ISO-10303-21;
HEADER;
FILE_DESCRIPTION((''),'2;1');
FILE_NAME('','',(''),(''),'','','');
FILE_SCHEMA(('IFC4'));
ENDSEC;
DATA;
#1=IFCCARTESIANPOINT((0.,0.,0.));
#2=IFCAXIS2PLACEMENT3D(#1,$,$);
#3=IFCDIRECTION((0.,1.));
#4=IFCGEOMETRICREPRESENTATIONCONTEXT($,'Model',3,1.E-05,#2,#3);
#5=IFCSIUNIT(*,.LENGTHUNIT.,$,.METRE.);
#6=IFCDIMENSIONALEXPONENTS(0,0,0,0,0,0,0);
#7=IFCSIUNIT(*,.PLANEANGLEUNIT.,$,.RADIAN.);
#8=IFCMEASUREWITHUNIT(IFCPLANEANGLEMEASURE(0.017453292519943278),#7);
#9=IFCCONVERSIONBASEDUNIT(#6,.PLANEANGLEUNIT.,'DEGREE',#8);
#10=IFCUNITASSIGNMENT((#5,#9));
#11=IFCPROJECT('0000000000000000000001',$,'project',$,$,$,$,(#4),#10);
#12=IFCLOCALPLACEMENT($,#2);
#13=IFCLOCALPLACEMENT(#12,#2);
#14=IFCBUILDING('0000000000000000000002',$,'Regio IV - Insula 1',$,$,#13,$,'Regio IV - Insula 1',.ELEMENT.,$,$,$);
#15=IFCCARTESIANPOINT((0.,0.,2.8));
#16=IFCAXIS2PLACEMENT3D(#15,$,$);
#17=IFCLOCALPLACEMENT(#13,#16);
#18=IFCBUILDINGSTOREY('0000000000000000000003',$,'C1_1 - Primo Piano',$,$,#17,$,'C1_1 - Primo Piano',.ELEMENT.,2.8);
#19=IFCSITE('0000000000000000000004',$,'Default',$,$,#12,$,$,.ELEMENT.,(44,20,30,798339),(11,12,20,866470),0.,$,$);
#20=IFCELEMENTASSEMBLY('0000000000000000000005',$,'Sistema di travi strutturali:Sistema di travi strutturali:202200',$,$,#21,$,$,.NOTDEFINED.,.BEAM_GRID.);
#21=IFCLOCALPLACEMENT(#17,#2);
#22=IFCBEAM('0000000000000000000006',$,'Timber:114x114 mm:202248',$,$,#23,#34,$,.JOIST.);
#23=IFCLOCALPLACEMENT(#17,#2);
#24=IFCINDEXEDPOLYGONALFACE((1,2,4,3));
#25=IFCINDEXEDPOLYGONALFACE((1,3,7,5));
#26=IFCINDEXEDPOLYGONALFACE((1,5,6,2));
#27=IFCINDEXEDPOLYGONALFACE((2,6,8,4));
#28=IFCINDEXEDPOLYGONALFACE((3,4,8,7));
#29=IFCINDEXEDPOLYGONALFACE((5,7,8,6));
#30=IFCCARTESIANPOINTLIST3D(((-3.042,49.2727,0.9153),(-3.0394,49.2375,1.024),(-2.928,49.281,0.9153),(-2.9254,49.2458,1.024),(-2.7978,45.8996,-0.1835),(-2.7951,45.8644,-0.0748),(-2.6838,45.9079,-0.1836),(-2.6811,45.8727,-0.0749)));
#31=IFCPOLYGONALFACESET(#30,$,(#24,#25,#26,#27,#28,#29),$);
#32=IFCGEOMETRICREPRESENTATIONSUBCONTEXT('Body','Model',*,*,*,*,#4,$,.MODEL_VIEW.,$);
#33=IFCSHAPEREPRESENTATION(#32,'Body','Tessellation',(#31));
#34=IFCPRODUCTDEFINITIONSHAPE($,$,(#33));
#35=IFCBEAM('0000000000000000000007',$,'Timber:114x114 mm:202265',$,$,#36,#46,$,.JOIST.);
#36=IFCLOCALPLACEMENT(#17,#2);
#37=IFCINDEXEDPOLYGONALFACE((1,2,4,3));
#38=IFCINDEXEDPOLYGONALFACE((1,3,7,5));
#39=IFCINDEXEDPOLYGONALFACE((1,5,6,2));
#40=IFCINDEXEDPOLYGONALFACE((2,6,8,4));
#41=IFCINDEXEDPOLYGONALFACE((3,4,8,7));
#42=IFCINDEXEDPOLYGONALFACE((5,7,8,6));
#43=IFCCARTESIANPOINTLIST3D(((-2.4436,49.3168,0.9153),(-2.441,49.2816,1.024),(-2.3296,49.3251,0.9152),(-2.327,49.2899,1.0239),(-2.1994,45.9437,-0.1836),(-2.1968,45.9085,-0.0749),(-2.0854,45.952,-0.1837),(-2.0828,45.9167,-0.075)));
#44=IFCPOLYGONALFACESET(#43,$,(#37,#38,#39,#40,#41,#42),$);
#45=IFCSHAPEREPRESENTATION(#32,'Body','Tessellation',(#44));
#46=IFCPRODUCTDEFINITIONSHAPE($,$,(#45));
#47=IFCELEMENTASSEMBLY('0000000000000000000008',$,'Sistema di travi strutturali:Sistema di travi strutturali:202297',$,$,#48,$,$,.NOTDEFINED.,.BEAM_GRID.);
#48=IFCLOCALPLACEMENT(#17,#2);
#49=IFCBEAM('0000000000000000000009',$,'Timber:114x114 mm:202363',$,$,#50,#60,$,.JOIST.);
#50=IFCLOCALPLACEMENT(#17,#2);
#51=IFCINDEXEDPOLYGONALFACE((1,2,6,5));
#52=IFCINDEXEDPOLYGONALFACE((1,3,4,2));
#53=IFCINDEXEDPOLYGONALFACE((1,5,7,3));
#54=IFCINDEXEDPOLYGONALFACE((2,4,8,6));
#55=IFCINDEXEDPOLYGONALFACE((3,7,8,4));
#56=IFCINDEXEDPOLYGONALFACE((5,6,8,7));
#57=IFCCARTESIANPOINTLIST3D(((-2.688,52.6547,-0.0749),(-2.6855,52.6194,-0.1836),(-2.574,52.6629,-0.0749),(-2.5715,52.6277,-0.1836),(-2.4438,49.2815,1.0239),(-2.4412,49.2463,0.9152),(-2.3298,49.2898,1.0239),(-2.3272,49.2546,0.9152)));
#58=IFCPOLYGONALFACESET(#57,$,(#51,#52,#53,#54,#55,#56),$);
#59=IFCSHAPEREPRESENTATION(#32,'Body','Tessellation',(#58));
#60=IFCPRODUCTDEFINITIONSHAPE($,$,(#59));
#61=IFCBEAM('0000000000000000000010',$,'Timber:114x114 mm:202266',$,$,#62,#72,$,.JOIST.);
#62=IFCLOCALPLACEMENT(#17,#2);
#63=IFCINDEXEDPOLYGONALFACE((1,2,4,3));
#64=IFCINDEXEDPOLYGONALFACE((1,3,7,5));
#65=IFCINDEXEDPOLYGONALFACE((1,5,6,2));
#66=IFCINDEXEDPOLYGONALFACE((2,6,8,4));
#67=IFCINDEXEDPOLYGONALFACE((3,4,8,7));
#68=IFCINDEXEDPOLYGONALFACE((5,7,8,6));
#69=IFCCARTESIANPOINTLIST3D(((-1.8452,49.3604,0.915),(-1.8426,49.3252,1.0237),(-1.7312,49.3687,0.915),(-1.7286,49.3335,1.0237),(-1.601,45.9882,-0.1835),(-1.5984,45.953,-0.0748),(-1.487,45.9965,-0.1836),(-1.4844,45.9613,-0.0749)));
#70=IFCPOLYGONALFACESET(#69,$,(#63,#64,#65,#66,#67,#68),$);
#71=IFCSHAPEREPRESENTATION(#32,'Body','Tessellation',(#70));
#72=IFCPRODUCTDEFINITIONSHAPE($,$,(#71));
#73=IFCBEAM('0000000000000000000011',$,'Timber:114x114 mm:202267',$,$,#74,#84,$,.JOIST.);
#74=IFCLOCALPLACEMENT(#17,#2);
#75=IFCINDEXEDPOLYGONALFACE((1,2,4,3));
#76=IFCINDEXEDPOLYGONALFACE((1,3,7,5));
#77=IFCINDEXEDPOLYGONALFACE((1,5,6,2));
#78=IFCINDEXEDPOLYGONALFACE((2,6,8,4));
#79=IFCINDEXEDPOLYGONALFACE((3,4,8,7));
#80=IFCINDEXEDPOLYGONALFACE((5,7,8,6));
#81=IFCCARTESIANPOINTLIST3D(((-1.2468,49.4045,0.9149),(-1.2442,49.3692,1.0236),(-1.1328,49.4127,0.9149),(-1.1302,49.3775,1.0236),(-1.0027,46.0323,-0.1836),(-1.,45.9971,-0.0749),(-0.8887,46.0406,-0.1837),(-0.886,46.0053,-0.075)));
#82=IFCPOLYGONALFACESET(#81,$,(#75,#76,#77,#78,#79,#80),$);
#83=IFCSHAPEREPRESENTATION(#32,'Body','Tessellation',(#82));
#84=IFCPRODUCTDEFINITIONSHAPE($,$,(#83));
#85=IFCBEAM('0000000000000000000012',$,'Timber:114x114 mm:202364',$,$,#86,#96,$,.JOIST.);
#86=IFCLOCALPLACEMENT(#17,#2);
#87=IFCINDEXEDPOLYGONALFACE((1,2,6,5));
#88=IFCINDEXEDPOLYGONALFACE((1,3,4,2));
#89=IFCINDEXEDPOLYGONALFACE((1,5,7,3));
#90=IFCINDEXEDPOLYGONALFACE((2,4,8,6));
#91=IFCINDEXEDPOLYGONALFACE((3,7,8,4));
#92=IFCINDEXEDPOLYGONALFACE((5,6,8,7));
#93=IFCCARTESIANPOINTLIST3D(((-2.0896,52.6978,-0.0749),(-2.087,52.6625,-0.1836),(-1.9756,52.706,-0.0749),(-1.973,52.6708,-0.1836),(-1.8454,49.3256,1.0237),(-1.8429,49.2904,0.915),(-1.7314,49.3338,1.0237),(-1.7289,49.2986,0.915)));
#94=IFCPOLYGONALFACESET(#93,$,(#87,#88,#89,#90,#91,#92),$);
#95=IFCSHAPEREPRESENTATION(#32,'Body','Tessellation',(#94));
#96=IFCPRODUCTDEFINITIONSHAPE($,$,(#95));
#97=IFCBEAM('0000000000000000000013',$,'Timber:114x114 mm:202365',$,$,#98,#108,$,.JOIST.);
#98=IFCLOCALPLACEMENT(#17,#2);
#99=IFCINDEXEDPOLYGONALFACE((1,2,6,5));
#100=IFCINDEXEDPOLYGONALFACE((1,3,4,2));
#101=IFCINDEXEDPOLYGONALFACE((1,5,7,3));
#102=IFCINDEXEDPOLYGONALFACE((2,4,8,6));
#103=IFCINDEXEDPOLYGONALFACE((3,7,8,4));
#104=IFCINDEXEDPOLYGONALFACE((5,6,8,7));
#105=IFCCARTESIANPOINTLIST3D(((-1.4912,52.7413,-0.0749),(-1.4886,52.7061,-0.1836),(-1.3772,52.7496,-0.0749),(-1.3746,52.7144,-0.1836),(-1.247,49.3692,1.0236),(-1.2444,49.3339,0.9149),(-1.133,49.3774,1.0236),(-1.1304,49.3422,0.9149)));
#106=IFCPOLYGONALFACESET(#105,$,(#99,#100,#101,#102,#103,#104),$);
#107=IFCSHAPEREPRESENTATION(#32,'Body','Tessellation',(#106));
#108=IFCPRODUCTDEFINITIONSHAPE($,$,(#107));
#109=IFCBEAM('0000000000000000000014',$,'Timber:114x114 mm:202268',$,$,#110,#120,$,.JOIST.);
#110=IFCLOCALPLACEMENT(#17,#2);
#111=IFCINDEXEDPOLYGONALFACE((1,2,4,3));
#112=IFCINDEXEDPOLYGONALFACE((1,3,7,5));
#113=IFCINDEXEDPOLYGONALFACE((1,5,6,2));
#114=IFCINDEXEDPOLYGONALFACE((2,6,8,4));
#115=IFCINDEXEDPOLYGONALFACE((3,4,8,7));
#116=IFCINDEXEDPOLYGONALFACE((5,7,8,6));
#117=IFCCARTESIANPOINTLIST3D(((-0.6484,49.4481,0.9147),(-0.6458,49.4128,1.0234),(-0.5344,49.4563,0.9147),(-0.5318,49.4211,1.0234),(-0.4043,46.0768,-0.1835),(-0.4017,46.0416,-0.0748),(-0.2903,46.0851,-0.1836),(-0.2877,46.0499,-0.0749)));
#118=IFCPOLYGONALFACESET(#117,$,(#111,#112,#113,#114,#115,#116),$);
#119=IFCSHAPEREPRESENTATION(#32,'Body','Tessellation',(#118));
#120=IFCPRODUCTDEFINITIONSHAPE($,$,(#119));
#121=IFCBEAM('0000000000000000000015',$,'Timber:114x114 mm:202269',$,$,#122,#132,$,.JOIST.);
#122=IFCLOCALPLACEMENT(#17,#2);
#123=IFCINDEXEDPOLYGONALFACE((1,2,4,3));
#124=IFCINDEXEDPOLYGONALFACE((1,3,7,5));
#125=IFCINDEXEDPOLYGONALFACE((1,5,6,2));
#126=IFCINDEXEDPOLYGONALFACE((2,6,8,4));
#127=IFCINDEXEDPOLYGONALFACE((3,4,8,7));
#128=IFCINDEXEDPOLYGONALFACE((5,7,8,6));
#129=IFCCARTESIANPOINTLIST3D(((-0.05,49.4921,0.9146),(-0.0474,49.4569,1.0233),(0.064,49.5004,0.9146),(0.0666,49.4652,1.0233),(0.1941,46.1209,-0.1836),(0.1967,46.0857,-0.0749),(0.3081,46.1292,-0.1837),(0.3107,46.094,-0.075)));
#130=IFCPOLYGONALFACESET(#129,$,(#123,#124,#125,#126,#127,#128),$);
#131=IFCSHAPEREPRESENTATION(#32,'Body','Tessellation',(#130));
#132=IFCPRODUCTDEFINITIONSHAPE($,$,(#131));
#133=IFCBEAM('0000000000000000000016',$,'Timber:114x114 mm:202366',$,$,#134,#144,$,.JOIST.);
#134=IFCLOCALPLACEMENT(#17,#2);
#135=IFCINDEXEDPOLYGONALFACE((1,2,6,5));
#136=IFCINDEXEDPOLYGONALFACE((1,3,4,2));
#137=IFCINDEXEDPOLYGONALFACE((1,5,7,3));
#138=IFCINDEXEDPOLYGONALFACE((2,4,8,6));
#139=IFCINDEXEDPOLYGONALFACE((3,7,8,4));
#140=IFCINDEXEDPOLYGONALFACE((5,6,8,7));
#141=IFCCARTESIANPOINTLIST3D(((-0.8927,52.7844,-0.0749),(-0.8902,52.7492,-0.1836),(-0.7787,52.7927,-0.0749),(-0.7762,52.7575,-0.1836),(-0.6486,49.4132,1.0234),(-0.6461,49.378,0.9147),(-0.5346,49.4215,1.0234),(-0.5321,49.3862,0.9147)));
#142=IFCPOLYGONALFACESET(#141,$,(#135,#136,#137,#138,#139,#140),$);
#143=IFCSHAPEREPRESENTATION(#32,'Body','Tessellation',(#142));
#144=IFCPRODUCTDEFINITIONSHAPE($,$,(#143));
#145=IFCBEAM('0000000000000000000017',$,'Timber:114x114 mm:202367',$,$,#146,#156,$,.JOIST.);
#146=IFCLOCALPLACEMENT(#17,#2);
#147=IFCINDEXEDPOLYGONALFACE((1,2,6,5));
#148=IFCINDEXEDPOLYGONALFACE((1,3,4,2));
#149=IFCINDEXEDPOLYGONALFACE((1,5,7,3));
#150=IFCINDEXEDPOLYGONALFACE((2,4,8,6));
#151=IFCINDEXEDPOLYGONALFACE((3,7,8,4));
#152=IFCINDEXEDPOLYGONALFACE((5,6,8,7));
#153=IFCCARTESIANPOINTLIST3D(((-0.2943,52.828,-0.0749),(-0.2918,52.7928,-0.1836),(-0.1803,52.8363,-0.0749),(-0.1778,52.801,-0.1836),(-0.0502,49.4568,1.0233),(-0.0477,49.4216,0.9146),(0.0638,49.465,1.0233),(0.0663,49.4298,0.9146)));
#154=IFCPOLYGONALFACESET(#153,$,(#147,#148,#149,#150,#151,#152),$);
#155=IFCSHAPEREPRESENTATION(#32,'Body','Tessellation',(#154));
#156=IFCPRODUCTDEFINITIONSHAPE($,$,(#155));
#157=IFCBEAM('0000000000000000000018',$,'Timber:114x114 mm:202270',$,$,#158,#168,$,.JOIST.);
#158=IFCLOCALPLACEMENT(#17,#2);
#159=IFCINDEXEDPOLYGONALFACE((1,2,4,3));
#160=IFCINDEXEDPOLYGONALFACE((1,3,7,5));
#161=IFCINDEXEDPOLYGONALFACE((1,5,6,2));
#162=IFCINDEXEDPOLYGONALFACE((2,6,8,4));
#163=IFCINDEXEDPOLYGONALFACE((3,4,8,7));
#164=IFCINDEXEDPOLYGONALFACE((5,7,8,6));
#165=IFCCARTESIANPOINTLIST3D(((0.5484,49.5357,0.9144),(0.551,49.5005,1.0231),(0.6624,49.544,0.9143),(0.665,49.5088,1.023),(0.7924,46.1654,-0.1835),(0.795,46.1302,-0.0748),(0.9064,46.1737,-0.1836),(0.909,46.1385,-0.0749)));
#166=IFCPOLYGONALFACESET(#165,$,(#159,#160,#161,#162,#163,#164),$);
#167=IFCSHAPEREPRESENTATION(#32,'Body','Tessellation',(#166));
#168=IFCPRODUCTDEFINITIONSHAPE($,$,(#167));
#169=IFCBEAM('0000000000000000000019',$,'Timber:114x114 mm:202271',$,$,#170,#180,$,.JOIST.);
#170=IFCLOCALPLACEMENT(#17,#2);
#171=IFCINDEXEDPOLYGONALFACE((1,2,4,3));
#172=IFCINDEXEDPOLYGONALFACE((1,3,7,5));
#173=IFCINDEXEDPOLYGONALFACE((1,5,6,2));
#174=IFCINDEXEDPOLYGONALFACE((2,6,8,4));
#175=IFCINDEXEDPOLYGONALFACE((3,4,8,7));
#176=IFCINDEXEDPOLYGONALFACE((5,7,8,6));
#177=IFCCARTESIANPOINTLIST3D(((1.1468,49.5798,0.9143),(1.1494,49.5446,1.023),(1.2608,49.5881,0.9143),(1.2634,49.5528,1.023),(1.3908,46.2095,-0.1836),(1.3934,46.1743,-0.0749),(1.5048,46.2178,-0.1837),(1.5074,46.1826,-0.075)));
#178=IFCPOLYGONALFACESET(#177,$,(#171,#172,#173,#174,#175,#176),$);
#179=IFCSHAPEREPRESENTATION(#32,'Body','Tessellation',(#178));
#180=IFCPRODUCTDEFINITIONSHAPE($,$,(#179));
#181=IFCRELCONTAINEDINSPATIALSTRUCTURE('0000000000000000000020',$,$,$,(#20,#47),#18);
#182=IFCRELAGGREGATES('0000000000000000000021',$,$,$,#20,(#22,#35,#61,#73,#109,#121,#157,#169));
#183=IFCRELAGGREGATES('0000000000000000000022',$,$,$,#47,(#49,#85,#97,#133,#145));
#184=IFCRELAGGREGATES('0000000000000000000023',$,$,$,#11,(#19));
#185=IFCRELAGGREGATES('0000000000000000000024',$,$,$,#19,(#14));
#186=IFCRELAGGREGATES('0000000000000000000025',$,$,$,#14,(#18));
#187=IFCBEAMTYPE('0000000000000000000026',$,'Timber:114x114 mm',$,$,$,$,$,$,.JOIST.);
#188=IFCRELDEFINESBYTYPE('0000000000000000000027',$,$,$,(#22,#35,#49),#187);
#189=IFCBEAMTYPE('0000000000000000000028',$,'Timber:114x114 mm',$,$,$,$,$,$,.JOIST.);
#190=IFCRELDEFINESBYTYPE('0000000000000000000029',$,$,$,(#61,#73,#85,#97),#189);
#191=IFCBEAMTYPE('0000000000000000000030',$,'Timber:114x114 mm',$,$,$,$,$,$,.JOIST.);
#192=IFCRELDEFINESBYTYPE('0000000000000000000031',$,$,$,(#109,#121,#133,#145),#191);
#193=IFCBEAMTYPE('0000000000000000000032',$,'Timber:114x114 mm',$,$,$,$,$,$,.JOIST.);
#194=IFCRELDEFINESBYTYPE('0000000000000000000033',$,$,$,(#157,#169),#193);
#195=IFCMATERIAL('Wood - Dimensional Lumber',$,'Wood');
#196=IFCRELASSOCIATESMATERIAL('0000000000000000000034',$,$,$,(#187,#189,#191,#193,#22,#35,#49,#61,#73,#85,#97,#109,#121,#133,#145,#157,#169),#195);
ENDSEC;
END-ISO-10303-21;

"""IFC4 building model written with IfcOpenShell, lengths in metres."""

from ifc_helpers import new_model, entity, si_unit, converted_unit, direction, frame, origin, origin_2d_with_axis, place, context, subcontext, project, spatial, rectangle, extrude, source, transform, mapped, material, material_profile, profile_set, profile_usage, type_object, type_shapes, element, aggregate, save


model = new_model("IFC4")

# Units and contexts
model_context = context("Model", 3, precision=1e-05, world=origin(), true_north=direction((0.0, 1.0)))
body_context = subcontext(model_context, "Body", "Model", "MODEL_VIEW")
ifc_project = project(units=[si_unit("LENGTHUNIT", "METRE"), converted_unit("PLANEANGLEUNIT", "DEGREE", entity("IfcPlaneAngleMeasure", 0.017453292519943278), si_unit("PLANEANGLEUNIT", "RADIAN"), dimensions=[0, 0, 0, 0, 0, 0, 0])], contexts=[model_context])

# Site, building, storey
site_placement = place(None, origin())
site = spatial("IfcSite", under=ifc_project, at=site_placement, Name="Default", CompositionType="ELEMENT", RefLatitude=(44, 20, 30, 798339), RefLongitude=(11, 12, 20, 866470), RefElevation=0.0)
building_placement = place(site_placement, origin())
building = spatial("IfcBuilding", under=site, at=building_placement, Name="Regio IV - Insula 1", LongName="Regio IV - Insula 1", CompositionType="ELEMENT")
storey_placement = place(building_placement, frame((0.0, 0.0, 2.8)))
storey = spatial("IfcBuildingStorey", under=building, at=storey_placement, Name="C1_1 - Primo Piano", LongName="C1_1 - Primo Piano", CompositionType="ELEMENT", Elevation=2.8)

# Element assembly, beams
assembly_1_placement = place(storey_placement, origin())
assembly_1 = element("IfcElementAssembly", 1, at=assembly_1_placement, inside=storey, Name="Sistema di travi strutturali:Sistema di travi strutturali:202200", AssemblyPlace="NOTDEFINED", PredefinedType="BEAM_GRID")
ifc_material = material(Name="Wood - Dimensional Lumber", Category="Wood")
ifc_material_profile = material_profile(ifc_material, rectangle(XDim=5.294, YDim=0.1143, at=origin_2d_with_axis()), Name="114x114 mm")
ifc_profile_set = profile_set([ifc_material_profile], Name="114x114 mm")
ifc_profile_usage = profile_usage(ifc_profile_set, cardinal=8)
beam_type_1 = type_object("IfcBeamType", Name="Timber:114x114 mm", PredefinedType="JOIST", material=ifc_profile_set)
shared_shape_1 = source(origin(), body_context, "Body", "SweptSolid", [
    extrude(rectangle(XDim=3.556, YDim=0.1143, at=origin_2d_with_axis()), frame((0.0, 0.0, -0.0572), z_axis=(0.0, 0.0, 1.0), x_axis=(-1.0, 0.0, 0.0)), (0.0, 0.0, 1.0), 0.1143),
])
type_shapes(beam_type_1, [shared_shape_1])
beam_1_placement = place(assembly_1_placement, frame((-2.8616, 47.5727, 0.4202), z_axis=(0.022823, -0.308173, 0.951057), x_axis=(0.068685, -0.948573, -0.309017)))
beam_1 = element("IfcBeam", 2, at=beam_1_placement, type_object=beam_type_1, material=ifc_profile_usage, Name="Timber:114x114 mm:202248", PredefinedType="JOIST", context=body_context, shape_type="MappedRepresentation", body=[
    mapped(shared_shape_1, transform((0.0, 0.0, 0.0), scale=1.0)),
])
beam_2_placement = place(assembly_1_placement, frame((-2.2632, 47.6168, 0.4201), z_axis=(0.022823, -0.308173, 0.951057), x_axis=(0.068685, -0.948573, -0.309017)))
beam_2 = element("IfcBeam", 3, at=beam_2_placement, type_object=beam_type_1, material=ifc_profile_usage, Name="Timber:114x114 mm:202265", PredefinedType="JOIST", context=body_context, shape_type="MappedRepresentation", body=[
    mapped(shared_shape_1, transform((0.0, 0.0, 0.0), scale=1.0)),
])

# Element assembly, beam
assembly_2_placement = place(storey_placement, origin())
assembly_2 = element("IfcElementAssembly", 4, at=assembly_2_placement, inside=storey, Name="Sistema di travi strutturali:Sistema di travi strutturali:202297", AssemblyPlace="NOTDEFINED", PredefinedType="BEAM_GRID")
beam_3_placement = place(assembly_2_placement, frame((-2.5076, 50.9546, 0.4201), z_axis=(-0.022317, 0.30821, 0.951057), x_axis=(0.068685, -0.948573, 0.309017)))
beam_3 = element("IfcBeam", 5, at=beam_3_placement, type_object=beam_type_1, material=ifc_profile_usage, Name="Timber:114x114 mm:202363", PredefinedType="JOIST", context=body_context, shape_type="MappedRepresentation", body=[
    mapped(shared_shape_1, transform((0.0, 0.0, 0.0), scale=1.0)),
])

# Beams
beam_type_2 = type_object("IfcBeamType", Name="Timber:114x114 mm", PredefinedType="JOIST", material=ifc_profile_set)
shared_shape_2 = source(origin(), body_context, "Body", "SweptSolid", [
    extrude(rectangle(XDim=3.555, YDim=0.1143, at=origin_2d_with_axis()), frame((0.0, 0.0, -0.0572), z_axis=(0.0, 0.0, 1.0), x_axis=(-1.0, 0.0, 0.0)), (0.0, 0.0, 1.0), 0.1143),
])
type_shapes(beam_type_2, [shared_shape_2])
beam_4_placement = place(assembly_1_placement, frame((-1.6648, 47.6608, 0.4201), z_axis=(0.022823, -0.308173, 0.951057), x_axis=(0.068685, -0.948573, -0.309017)))
beam_4 = element("IfcBeam", 6, at=beam_4_placement, type_object=beam_type_2, material=ifc_profile_usage, Name="Timber:114x114 mm:202266", PredefinedType="JOIST", context=body_context, shape_type="MappedRepresentation", body=[
    mapped(shared_shape_2, transform((0.0, 0.0, 0.0), scale=1.0)),
])
beam_5_placement = place(assembly_1_placement, frame((-1.0664, 47.7049, 0.42), z_axis=(0.022823, -0.308173, 0.951057), x_axis=(0.068685, -0.948573, -0.309017)))
beam_5 = element("IfcBeam", 7, at=beam_5_placement, type_object=beam_type_2, material=ifc_profile_usage, Name="Timber:114x114 mm:202267", PredefinedType="JOIST", context=body_context, shape_type="MappedRepresentation", body=[
    mapped(shared_shape_2, transform((0.0, 0.0, 0.0), scale=1.0)),
])
beam_6_placement = place(assembly_2_placement, frame((-1.9092, 50.9982, 0.4201), z_axis=(-0.022317, 0.30821, 0.951057), x_axis=(0.068685, -0.948573, 0.309017)))
beam_6 = element("IfcBeam", 8, at=beam_6_placement, type_object=beam_type_2, material=ifc_profile_usage, Name="Timber:114x114 mm:202364", PredefinedType="JOIST", context=body_context, shape_type="MappedRepresentation", body=[
    mapped(shared_shape_2, transform((0.0, 0.0, 0.0), scale=1.0)),
])
beam_7_placement = place(assembly_2_placement, frame((-1.3108, 51.0418, 0.42), z_axis=(-0.022317, 0.30821, 0.951057), x_axis=(0.068685, -0.948573, 0.309017)))
beam_7 = element("IfcBeam", 9, at=beam_7_placement, type_object=beam_type_2, material=ifc_profile_usage, Name="Timber:114x114 mm:202365", PredefinedType="JOIST", context=body_context, shape_type="MappedRepresentation", body=[
    mapped(shared_shape_2, transform((0.0, 0.0, 0.0), scale=1.0)),
])
beam_type_3 = type_object("IfcBeamType", Name="Timber:114x114 mm", PredefinedType="JOIST", material=ifc_profile_set)
shared_shape_3 = source(origin(), body_context, "Body", "SweptSolid", [
    extrude(rectangle(XDim=3.554, YDim=0.1143, at=origin_2d_with_axis()), frame((0.0, 0.0, -0.0572), z_axis=(0.0, 0.0, 1.0), x_axis=(-1.0, 0.0, 0.0)), (0.0, 0.0, 1.0), 0.1143),
])
type_shapes(beam_type_3, [shared_shape_3])
beam_8_placement = place(assembly_1_placement, frame((-0.4681, 47.749, 0.4199), z_axis=(0.022823, -0.308173, 0.951057), x_axis=(0.068685, -0.948573, -0.309017)))
beam_8 = element("IfcBeam", 10, at=beam_8_placement, type_object=beam_type_3, material=ifc_profile_usage, Name="Timber:114x114 mm:202268", PredefinedType="JOIST", context=body_context, shape_type="MappedRepresentation", body=[
    mapped(shared_shape_3, transform((0.0, 0.0, 0.0), scale=1.0)),
])
beam_9_placement = place(assembly_1_placement, frame((0.1303, 47.793, 0.4198), z_axis=(0.022823, -0.308173, 0.951057), x_axis=(0.068685, -0.948573, -0.309017)))
beam_9 = element("IfcBeam", 11, at=beam_9_placement, type_object=beam_type_3, material=ifc_profile_usage, Name="Timber:114x114 mm:202269", PredefinedType="JOIST", context=body_context, shape_type="MappedRepresentation", body=[
    mapped(shared_shape_3, transform((0.0, 0.0, 0.0), scale=1.0)),
])
beam_10_placement = place(assembly_2_placement, frame((-0.7124, 51.0853, 0.4199), z_axis=(-0.022317, 0.30821, 0.951057), x_axis=(0.068685, -0.948573, 0.309017)))
beam_10 = element("IfcBeam", 12, at=beam_10_placement, type_object=beam_type_3, material=ifc_profile_usage, Name="Timber:114x114 mm:202366", PredefinedType="JOIST", context=body_context, shape_type="MappedRepresentation", body=[
    mapped(shared_shape_3, transform((0.0, 0.0, 0.0), scale=1.0)),
])
beam_11_placement = place(assembly_2_placement, frame((-0.114, 51.1289, 0.4198), z_axis=(-0.022317, 0.30821, 0.951057), x_axis=(0.068685, -0.948573, 0.309017)))
beam_11 = element("IfcBeam", 13, at=beam_11_placement, type_object=beam_type_3, material=ifc_profile_usage, Name="Timber:114x114 mm:202367", PredefinedType="JOIST", context=body_context, shape_type="MappedRepresentation", body=[
    mapped(shared_shape_3, transform((0.0, 0.0, 0.0), scale=1.0)),
])
beam_type_4 = type_object("IfcBeamType", Name="Timber:114x114 mm", PredefinedType="JOIST", material=ifc_profile_set)
shared_shape_4 = source(origin(), body_context, "Body", "SweptSolid", [
    extrude(rectangle(XDim=3.553, YDim=0.1143, at=origin_2d_with_axis()), frame((0.0, 0.0, -0.0572), z_axis=(0.0, 0.0, 1.0), x_axis=(-1.0, 0.0, 0.0)), (0.0, 0.0, 1.0), 0.1143),
])
type_shapes(beam_type_4, [shared_shape_4])
beam_12_placement = place(assembly_1_placement, frame((0.7287, 47.8371, 0.4197), z_axis=(0.022823, -0.308173, 0.951057), x_axis=(0.068685, -0.948573, -0.309017)))
beam_12 = element("IfcBeam", 14, at=beam_12_placement, type_object=beam_type_4, material=ifc_profile_usage, Name="Timber:114x114 mm:202270", PredefinedType="JOIST", context=body_context, shape_type="MappedRepresentation", body=[
    mapped(shared_shape_4, transform((0.0, 0.0, 0.0), scale=1.0)),
])
beam_13_placement = place(assembly_1_placement, frame((1.3271, 47.8812, 0.4197), z_axis=(0.022823, -0.308173, 0.951057), x_axis=(0.068685, -0.948573, -0.309017)))
beam_13 = element("IfcBeam", 15, at=beam_13_placement, type_object=beam_type_4, material=ifc_profile_usage, Name="Timber:114x114 mm:202271", PredefinedType="JOIST", context=body_context, shape_type="MappedRepresentation", body=[
    mapped(shared_shape_4, transform((0.0, 0.0, 0.0), scale=1.0)),
])
aggregate(assembly_1, [beam_1, beam_2, beam_4, beam_5, beam_8, beam_9, beam_12, beam_13])
aggregate(assembly_2, [beam_3, beam_6, beam_7, beam_10, beam_11])

save(model, "model.ifc")
